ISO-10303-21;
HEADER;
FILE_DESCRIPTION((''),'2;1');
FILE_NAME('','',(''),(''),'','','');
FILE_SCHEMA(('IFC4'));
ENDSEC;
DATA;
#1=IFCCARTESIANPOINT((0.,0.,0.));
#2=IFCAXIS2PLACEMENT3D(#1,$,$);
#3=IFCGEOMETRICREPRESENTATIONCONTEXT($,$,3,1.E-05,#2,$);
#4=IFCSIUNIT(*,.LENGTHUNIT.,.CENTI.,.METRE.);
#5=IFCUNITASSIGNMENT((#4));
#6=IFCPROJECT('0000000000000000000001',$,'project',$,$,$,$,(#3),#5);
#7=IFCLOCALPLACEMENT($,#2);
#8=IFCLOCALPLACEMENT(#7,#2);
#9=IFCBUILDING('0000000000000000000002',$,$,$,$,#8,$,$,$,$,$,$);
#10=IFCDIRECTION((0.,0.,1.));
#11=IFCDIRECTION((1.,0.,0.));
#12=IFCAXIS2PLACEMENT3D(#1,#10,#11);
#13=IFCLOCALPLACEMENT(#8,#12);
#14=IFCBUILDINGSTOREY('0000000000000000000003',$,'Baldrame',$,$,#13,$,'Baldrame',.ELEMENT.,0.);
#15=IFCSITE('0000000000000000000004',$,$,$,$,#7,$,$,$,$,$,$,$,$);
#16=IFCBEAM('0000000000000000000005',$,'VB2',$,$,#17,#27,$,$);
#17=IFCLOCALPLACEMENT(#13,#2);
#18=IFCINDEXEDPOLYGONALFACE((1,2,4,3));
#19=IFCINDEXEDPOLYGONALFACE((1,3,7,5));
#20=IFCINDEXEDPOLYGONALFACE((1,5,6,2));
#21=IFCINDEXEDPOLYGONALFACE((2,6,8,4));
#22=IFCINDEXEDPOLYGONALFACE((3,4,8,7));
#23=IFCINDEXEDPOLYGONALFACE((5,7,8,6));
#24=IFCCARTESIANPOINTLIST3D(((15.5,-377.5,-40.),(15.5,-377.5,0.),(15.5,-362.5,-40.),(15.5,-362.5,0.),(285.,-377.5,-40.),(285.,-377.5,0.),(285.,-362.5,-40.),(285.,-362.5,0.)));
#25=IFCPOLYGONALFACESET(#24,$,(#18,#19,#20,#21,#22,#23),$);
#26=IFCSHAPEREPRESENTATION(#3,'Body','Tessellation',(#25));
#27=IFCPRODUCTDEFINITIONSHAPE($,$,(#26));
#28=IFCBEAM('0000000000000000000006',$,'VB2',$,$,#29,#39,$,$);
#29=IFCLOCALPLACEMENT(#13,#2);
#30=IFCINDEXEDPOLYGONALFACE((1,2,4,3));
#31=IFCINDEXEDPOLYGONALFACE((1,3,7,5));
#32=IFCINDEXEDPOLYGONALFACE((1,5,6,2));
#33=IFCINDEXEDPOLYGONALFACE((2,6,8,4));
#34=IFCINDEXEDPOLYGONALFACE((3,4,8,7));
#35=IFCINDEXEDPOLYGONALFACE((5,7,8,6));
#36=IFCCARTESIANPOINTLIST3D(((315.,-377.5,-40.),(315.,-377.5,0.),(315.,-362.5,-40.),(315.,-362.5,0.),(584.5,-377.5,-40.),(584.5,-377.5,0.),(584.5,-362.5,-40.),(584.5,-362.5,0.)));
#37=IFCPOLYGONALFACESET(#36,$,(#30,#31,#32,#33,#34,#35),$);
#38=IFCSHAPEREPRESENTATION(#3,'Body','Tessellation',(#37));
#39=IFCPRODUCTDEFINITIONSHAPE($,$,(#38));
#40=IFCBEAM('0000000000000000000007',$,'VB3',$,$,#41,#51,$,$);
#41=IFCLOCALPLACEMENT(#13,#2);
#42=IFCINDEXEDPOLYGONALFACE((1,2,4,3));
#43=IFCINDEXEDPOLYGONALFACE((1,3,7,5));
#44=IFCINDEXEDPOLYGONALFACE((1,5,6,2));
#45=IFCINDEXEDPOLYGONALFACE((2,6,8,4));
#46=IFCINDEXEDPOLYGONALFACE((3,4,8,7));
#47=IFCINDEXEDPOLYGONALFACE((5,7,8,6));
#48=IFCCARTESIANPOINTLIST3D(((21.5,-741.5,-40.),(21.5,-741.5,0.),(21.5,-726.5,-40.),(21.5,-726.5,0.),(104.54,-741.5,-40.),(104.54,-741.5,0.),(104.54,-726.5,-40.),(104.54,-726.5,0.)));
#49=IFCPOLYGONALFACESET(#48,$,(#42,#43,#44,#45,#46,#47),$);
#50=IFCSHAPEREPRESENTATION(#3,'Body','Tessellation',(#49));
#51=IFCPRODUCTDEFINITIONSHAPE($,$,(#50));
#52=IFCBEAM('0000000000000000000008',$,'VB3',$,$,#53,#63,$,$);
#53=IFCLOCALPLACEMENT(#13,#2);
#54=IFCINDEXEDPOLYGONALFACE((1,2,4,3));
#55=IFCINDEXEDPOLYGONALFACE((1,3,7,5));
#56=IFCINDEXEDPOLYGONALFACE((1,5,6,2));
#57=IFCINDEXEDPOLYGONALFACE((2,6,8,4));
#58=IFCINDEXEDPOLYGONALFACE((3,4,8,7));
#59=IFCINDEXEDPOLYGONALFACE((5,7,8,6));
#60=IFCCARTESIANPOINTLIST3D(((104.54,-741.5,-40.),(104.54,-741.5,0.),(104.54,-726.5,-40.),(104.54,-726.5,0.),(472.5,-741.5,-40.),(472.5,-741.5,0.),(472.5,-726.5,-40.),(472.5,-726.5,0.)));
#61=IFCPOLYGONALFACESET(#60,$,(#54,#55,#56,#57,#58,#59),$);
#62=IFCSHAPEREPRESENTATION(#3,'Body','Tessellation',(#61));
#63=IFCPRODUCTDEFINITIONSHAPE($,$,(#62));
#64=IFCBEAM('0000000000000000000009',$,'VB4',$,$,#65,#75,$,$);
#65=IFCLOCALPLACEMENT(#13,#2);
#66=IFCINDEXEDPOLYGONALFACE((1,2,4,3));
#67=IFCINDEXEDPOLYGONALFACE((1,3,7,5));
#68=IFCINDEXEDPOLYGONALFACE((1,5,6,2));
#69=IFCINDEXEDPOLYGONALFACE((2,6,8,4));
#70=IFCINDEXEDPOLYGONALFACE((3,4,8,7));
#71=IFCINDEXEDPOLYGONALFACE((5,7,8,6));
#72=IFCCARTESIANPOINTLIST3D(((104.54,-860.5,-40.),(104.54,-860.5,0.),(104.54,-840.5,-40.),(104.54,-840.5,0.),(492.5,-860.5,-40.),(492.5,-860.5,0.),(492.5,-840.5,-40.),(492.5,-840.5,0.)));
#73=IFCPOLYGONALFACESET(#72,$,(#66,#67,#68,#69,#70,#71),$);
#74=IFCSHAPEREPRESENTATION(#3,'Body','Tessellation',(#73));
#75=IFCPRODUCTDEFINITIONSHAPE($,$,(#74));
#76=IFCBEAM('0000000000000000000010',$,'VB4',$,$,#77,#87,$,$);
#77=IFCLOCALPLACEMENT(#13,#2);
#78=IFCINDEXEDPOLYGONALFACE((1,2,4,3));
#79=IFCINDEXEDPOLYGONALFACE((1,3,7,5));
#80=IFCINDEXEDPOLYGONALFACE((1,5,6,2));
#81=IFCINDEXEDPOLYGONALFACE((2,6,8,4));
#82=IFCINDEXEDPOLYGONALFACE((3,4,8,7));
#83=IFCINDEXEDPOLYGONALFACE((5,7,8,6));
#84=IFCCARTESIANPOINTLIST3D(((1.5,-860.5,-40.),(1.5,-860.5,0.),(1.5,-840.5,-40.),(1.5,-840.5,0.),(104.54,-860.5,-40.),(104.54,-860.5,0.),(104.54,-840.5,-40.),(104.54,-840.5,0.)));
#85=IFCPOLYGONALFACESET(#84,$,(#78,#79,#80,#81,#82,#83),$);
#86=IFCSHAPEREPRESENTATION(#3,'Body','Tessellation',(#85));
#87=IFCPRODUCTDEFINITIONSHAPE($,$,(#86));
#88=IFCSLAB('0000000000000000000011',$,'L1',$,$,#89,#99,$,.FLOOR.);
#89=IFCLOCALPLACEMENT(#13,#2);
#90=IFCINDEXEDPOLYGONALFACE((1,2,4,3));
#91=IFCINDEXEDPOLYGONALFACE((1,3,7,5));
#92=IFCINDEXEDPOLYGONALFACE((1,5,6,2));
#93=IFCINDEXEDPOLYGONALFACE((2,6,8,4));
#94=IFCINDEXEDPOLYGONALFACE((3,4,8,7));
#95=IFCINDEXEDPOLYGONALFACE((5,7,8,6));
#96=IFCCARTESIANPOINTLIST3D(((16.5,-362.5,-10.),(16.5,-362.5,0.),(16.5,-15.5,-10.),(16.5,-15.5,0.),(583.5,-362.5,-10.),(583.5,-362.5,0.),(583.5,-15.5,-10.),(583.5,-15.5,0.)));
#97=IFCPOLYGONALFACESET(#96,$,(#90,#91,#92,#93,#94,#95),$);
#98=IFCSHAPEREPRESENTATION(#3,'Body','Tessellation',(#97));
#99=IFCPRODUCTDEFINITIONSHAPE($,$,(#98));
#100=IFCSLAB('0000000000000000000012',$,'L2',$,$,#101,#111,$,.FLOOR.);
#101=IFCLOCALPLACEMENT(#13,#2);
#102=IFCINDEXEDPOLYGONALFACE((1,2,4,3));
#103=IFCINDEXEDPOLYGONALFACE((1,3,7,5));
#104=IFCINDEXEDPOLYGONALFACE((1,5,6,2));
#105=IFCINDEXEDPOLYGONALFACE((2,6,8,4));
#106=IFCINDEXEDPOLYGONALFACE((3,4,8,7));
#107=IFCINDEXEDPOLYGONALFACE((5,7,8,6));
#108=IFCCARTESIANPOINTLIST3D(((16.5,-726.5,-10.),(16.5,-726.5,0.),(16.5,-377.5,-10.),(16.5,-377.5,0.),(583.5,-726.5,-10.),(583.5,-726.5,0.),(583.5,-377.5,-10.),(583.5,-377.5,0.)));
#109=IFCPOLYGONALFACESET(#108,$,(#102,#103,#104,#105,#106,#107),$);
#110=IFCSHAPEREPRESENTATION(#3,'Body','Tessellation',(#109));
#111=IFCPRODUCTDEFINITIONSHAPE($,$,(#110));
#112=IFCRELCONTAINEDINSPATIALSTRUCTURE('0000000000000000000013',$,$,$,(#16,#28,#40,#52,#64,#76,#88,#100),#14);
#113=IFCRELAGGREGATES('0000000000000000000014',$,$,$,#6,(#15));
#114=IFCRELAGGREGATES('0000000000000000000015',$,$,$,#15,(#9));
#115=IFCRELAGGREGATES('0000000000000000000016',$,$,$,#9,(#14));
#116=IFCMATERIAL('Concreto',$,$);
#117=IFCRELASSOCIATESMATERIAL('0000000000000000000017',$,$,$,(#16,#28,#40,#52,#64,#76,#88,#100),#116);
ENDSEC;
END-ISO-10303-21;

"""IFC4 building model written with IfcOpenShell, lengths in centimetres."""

from ifc_helpers import new_model, si_unit, frame, origin, origin_with_axes, place, context, project, spatial, polyline, outline, extrude, material, element, save


model = new_model("IFC4")

# Units and contexts
context_of_model = context(None, 3, precision=1e-05, world=origin())
ifc_project = project(units=[si_unit("LENGTHUNIT", "METRE", prefix="CENTI")], contexts=[context_of_model])

# Site, building, storey
site_placement = place(None, origin())
site = spatial("IfcSite", under=ifc_project, at=site_placement)
building_placement = place(site_placement, origin())
building = spatial("IfcBuilding", under=site, at=building_placement)
storey_placement = place(building_placement, origin_with_axes())
storey = spatial("IfcBuildingStorey", under=building, at=storey_placement, Name="Baldrame", LongName="Baldrame", CompositionType="ELEMENT", Elevation=0.0)

# Shared definitions
ifc_material = material(Name="Concreto")

# Beams
for number, where, z_axis, x_axis, name in (
    (1, (150.25, -370.0, 0.0), (0.0, 0.0, 1.0), (1.0, 0.0, 0.0), "VB2"),
    (2, (449.75, -370.0, 0.0), (0.0, 0.0, 1.0), (1.0, 0.0, 0.0), "VB2"),
):
    element("IfcBeam", number, at=place(storey_placement, frame(where, z_axis=z_axis, x_axis=x_axis)), inside=storey, material=ifc_material, Name=name, context=context_of_model, shape_type="SolidModel", body=[
        extrude(outline(polyline([(-7.5, -20.0), (7.5, -20.0), (7.5, 20.0), (-7.5, 20.0), (-7.5, -20.0)])), frame((-134.75, 0.0, -20.0), z_axis=(1.0, 0.0, 0.0), x_axis=(0.0, -1.0, 0.0)), (0.0, 0.0, 1.0), 269.5),
    ])
beam_1_placement = place(storey_placement, frame((63.02, -734.0, 0.0), z_axis=(0.0, 0.0, 1.0), x_axis=(1.0, 0.0, 0.0)))
element("IfcBeam", 3, at=beam_1_placement, inside=storey, material=ifc_material, Name="VB3", context=context_of_model, shape_type="SolidModel", body=[
    extrude(outline(polyline([(-7.5, -20.0), (7.5, -20.0), (7.5, 20.0), (-7.5, 20.0), (-7.5, -20.0)])), frame((-41.52, 0.0, -20.0), z_axis=(1.0, 0.0, 0.0), x_axis=(0.0, -1.0, 0.0)), (0.0, 0.0, 1.0), 83.04),
])
beam_2_placement = place(storey_placement, frame((288.52, -734.0, 0.0), z_axis=(0.0, 0.0, 1.0), x_axis=(1.0, 0.0, 0.0)))
element("IfcBeam", 4, at=beam_2_placement, inside=storey, material=ifc_material, Name="VB3", context=context_of_model, shape_type="SolidModel", body=[
    extrude(outline(polyline([(-7.5, -20.0), (7.5, -20.0), (7.5, 20.0), (-7.5, 20.0), (-7.5, -20.0)])), frame((-183.98, 0.0, -20.0), z_axis=(1.0, 0.0, 0.0), x_axis=(0.0, -1.0, 0.0)), (0.0, 0.0, 1.0), 367.96),
])
beam_3_placement = place(storey_placement, frame((298.52, -850.5, 0.0), z_axis=(0.0, 0.0, 1.0), x_axis=(1.0, 0.0, 0.0)))
element("IfcBeam", 5, at=beam_3_placement, inside=storey, material=ifc_material, Name="VB4", context=context_of_model, shape_type="SolidModel", body=[
    extrude(outline(polyline([(-10.0, -20.0), (10.0, -20.0), (10.0, 20.0), (-10.0, 20.0), (-10.0, -20.0)])), frame((-193.98, 0.0, -20.0), z_axis=(1.0, 0.0, 0.0), x_axis=(0.0, -1.0, 0.0)), (0.0, 0.0, 1.0), 387.96),
])
beam_4_placement = place(storey_placement, frame((53.02, -850.5, 0.0), z_axis=(0.0, 0.0, 1.0), x_axis=(1.0, 0.0, 0.0)))
element("IfcBeam", 6, at=beam_4_placement, inside=storey, material=ifc_material, Name="VB4", context=context_of_model, shape_type="SolidModel", body=[
    extrude(outline(polyline([(-10.0, -20.0), (10.0, -20.0), (10.0, 20.0), (-10.0, 20.0), (-10.0, -20.0)])), frame((-51.52, 0.0, -20.0), z_axis=(1.0, 0.0, 0.0), x_axis=(0.0, -1.0, 0.0)), (0.0, 0.0, 1.0), 103.04),
])

# Slabs
slab_1_placement = place(storey_placement, frame((300.0, -189.0, 0.0), z_axis=(0.0, 0.0, 1.0), x_axis=(1.0, 0.0, 0.0)))
element("IfcSlab", 7, at=slab_1_placement, inside=storey, material=ifc_material, Name="L1", PredefinedType="FLOOR", context=context_of_model, shape_type="SolidModel", body=[
    extrude(outline(polyline([(283.5, 173.5), (-283.5, 173.5), (-283.5, -173.5), (283.5, -173.5), (283.5, 173.5), (283.5, 173.5)])), frame((0.0, 0.0, -10.0), z_axis=(0.0, 0.0, 1.0), x_axis=(1.0, 0.0, 0.0)), (0.0, 0.0, 1.0), 10.0),
])
slab_2_placement = place(storey_placement, frame((300.0, -552.0, 0.0), z_axis=(0.0, 0.0, 1.0), x_axis=(1.0, 0.0, 0.0)))
element("IfcSlab", 8, at=slab_2_placement, inside=storey, material=ifc_material, Name="L2", PredefinedType="FLOOR", context=context_of_model, shape_type="SolidModel", body=[
    extrude(outline(polyline([(283.5, 174.5), (-283.5, 174.5), (-283.5, -174.5), (283.5, -174.5), (283.5, 174.5), (283.5, 174.5)])), frame((0.0, 0.0, -10.0), z_axis=(0.0, 0.0, 1.0), x_axis=(1.0, 0.0, 0.0)), (0.0, 0.0, 1.0), 10.0),
])

save(model, "model.ifc")
